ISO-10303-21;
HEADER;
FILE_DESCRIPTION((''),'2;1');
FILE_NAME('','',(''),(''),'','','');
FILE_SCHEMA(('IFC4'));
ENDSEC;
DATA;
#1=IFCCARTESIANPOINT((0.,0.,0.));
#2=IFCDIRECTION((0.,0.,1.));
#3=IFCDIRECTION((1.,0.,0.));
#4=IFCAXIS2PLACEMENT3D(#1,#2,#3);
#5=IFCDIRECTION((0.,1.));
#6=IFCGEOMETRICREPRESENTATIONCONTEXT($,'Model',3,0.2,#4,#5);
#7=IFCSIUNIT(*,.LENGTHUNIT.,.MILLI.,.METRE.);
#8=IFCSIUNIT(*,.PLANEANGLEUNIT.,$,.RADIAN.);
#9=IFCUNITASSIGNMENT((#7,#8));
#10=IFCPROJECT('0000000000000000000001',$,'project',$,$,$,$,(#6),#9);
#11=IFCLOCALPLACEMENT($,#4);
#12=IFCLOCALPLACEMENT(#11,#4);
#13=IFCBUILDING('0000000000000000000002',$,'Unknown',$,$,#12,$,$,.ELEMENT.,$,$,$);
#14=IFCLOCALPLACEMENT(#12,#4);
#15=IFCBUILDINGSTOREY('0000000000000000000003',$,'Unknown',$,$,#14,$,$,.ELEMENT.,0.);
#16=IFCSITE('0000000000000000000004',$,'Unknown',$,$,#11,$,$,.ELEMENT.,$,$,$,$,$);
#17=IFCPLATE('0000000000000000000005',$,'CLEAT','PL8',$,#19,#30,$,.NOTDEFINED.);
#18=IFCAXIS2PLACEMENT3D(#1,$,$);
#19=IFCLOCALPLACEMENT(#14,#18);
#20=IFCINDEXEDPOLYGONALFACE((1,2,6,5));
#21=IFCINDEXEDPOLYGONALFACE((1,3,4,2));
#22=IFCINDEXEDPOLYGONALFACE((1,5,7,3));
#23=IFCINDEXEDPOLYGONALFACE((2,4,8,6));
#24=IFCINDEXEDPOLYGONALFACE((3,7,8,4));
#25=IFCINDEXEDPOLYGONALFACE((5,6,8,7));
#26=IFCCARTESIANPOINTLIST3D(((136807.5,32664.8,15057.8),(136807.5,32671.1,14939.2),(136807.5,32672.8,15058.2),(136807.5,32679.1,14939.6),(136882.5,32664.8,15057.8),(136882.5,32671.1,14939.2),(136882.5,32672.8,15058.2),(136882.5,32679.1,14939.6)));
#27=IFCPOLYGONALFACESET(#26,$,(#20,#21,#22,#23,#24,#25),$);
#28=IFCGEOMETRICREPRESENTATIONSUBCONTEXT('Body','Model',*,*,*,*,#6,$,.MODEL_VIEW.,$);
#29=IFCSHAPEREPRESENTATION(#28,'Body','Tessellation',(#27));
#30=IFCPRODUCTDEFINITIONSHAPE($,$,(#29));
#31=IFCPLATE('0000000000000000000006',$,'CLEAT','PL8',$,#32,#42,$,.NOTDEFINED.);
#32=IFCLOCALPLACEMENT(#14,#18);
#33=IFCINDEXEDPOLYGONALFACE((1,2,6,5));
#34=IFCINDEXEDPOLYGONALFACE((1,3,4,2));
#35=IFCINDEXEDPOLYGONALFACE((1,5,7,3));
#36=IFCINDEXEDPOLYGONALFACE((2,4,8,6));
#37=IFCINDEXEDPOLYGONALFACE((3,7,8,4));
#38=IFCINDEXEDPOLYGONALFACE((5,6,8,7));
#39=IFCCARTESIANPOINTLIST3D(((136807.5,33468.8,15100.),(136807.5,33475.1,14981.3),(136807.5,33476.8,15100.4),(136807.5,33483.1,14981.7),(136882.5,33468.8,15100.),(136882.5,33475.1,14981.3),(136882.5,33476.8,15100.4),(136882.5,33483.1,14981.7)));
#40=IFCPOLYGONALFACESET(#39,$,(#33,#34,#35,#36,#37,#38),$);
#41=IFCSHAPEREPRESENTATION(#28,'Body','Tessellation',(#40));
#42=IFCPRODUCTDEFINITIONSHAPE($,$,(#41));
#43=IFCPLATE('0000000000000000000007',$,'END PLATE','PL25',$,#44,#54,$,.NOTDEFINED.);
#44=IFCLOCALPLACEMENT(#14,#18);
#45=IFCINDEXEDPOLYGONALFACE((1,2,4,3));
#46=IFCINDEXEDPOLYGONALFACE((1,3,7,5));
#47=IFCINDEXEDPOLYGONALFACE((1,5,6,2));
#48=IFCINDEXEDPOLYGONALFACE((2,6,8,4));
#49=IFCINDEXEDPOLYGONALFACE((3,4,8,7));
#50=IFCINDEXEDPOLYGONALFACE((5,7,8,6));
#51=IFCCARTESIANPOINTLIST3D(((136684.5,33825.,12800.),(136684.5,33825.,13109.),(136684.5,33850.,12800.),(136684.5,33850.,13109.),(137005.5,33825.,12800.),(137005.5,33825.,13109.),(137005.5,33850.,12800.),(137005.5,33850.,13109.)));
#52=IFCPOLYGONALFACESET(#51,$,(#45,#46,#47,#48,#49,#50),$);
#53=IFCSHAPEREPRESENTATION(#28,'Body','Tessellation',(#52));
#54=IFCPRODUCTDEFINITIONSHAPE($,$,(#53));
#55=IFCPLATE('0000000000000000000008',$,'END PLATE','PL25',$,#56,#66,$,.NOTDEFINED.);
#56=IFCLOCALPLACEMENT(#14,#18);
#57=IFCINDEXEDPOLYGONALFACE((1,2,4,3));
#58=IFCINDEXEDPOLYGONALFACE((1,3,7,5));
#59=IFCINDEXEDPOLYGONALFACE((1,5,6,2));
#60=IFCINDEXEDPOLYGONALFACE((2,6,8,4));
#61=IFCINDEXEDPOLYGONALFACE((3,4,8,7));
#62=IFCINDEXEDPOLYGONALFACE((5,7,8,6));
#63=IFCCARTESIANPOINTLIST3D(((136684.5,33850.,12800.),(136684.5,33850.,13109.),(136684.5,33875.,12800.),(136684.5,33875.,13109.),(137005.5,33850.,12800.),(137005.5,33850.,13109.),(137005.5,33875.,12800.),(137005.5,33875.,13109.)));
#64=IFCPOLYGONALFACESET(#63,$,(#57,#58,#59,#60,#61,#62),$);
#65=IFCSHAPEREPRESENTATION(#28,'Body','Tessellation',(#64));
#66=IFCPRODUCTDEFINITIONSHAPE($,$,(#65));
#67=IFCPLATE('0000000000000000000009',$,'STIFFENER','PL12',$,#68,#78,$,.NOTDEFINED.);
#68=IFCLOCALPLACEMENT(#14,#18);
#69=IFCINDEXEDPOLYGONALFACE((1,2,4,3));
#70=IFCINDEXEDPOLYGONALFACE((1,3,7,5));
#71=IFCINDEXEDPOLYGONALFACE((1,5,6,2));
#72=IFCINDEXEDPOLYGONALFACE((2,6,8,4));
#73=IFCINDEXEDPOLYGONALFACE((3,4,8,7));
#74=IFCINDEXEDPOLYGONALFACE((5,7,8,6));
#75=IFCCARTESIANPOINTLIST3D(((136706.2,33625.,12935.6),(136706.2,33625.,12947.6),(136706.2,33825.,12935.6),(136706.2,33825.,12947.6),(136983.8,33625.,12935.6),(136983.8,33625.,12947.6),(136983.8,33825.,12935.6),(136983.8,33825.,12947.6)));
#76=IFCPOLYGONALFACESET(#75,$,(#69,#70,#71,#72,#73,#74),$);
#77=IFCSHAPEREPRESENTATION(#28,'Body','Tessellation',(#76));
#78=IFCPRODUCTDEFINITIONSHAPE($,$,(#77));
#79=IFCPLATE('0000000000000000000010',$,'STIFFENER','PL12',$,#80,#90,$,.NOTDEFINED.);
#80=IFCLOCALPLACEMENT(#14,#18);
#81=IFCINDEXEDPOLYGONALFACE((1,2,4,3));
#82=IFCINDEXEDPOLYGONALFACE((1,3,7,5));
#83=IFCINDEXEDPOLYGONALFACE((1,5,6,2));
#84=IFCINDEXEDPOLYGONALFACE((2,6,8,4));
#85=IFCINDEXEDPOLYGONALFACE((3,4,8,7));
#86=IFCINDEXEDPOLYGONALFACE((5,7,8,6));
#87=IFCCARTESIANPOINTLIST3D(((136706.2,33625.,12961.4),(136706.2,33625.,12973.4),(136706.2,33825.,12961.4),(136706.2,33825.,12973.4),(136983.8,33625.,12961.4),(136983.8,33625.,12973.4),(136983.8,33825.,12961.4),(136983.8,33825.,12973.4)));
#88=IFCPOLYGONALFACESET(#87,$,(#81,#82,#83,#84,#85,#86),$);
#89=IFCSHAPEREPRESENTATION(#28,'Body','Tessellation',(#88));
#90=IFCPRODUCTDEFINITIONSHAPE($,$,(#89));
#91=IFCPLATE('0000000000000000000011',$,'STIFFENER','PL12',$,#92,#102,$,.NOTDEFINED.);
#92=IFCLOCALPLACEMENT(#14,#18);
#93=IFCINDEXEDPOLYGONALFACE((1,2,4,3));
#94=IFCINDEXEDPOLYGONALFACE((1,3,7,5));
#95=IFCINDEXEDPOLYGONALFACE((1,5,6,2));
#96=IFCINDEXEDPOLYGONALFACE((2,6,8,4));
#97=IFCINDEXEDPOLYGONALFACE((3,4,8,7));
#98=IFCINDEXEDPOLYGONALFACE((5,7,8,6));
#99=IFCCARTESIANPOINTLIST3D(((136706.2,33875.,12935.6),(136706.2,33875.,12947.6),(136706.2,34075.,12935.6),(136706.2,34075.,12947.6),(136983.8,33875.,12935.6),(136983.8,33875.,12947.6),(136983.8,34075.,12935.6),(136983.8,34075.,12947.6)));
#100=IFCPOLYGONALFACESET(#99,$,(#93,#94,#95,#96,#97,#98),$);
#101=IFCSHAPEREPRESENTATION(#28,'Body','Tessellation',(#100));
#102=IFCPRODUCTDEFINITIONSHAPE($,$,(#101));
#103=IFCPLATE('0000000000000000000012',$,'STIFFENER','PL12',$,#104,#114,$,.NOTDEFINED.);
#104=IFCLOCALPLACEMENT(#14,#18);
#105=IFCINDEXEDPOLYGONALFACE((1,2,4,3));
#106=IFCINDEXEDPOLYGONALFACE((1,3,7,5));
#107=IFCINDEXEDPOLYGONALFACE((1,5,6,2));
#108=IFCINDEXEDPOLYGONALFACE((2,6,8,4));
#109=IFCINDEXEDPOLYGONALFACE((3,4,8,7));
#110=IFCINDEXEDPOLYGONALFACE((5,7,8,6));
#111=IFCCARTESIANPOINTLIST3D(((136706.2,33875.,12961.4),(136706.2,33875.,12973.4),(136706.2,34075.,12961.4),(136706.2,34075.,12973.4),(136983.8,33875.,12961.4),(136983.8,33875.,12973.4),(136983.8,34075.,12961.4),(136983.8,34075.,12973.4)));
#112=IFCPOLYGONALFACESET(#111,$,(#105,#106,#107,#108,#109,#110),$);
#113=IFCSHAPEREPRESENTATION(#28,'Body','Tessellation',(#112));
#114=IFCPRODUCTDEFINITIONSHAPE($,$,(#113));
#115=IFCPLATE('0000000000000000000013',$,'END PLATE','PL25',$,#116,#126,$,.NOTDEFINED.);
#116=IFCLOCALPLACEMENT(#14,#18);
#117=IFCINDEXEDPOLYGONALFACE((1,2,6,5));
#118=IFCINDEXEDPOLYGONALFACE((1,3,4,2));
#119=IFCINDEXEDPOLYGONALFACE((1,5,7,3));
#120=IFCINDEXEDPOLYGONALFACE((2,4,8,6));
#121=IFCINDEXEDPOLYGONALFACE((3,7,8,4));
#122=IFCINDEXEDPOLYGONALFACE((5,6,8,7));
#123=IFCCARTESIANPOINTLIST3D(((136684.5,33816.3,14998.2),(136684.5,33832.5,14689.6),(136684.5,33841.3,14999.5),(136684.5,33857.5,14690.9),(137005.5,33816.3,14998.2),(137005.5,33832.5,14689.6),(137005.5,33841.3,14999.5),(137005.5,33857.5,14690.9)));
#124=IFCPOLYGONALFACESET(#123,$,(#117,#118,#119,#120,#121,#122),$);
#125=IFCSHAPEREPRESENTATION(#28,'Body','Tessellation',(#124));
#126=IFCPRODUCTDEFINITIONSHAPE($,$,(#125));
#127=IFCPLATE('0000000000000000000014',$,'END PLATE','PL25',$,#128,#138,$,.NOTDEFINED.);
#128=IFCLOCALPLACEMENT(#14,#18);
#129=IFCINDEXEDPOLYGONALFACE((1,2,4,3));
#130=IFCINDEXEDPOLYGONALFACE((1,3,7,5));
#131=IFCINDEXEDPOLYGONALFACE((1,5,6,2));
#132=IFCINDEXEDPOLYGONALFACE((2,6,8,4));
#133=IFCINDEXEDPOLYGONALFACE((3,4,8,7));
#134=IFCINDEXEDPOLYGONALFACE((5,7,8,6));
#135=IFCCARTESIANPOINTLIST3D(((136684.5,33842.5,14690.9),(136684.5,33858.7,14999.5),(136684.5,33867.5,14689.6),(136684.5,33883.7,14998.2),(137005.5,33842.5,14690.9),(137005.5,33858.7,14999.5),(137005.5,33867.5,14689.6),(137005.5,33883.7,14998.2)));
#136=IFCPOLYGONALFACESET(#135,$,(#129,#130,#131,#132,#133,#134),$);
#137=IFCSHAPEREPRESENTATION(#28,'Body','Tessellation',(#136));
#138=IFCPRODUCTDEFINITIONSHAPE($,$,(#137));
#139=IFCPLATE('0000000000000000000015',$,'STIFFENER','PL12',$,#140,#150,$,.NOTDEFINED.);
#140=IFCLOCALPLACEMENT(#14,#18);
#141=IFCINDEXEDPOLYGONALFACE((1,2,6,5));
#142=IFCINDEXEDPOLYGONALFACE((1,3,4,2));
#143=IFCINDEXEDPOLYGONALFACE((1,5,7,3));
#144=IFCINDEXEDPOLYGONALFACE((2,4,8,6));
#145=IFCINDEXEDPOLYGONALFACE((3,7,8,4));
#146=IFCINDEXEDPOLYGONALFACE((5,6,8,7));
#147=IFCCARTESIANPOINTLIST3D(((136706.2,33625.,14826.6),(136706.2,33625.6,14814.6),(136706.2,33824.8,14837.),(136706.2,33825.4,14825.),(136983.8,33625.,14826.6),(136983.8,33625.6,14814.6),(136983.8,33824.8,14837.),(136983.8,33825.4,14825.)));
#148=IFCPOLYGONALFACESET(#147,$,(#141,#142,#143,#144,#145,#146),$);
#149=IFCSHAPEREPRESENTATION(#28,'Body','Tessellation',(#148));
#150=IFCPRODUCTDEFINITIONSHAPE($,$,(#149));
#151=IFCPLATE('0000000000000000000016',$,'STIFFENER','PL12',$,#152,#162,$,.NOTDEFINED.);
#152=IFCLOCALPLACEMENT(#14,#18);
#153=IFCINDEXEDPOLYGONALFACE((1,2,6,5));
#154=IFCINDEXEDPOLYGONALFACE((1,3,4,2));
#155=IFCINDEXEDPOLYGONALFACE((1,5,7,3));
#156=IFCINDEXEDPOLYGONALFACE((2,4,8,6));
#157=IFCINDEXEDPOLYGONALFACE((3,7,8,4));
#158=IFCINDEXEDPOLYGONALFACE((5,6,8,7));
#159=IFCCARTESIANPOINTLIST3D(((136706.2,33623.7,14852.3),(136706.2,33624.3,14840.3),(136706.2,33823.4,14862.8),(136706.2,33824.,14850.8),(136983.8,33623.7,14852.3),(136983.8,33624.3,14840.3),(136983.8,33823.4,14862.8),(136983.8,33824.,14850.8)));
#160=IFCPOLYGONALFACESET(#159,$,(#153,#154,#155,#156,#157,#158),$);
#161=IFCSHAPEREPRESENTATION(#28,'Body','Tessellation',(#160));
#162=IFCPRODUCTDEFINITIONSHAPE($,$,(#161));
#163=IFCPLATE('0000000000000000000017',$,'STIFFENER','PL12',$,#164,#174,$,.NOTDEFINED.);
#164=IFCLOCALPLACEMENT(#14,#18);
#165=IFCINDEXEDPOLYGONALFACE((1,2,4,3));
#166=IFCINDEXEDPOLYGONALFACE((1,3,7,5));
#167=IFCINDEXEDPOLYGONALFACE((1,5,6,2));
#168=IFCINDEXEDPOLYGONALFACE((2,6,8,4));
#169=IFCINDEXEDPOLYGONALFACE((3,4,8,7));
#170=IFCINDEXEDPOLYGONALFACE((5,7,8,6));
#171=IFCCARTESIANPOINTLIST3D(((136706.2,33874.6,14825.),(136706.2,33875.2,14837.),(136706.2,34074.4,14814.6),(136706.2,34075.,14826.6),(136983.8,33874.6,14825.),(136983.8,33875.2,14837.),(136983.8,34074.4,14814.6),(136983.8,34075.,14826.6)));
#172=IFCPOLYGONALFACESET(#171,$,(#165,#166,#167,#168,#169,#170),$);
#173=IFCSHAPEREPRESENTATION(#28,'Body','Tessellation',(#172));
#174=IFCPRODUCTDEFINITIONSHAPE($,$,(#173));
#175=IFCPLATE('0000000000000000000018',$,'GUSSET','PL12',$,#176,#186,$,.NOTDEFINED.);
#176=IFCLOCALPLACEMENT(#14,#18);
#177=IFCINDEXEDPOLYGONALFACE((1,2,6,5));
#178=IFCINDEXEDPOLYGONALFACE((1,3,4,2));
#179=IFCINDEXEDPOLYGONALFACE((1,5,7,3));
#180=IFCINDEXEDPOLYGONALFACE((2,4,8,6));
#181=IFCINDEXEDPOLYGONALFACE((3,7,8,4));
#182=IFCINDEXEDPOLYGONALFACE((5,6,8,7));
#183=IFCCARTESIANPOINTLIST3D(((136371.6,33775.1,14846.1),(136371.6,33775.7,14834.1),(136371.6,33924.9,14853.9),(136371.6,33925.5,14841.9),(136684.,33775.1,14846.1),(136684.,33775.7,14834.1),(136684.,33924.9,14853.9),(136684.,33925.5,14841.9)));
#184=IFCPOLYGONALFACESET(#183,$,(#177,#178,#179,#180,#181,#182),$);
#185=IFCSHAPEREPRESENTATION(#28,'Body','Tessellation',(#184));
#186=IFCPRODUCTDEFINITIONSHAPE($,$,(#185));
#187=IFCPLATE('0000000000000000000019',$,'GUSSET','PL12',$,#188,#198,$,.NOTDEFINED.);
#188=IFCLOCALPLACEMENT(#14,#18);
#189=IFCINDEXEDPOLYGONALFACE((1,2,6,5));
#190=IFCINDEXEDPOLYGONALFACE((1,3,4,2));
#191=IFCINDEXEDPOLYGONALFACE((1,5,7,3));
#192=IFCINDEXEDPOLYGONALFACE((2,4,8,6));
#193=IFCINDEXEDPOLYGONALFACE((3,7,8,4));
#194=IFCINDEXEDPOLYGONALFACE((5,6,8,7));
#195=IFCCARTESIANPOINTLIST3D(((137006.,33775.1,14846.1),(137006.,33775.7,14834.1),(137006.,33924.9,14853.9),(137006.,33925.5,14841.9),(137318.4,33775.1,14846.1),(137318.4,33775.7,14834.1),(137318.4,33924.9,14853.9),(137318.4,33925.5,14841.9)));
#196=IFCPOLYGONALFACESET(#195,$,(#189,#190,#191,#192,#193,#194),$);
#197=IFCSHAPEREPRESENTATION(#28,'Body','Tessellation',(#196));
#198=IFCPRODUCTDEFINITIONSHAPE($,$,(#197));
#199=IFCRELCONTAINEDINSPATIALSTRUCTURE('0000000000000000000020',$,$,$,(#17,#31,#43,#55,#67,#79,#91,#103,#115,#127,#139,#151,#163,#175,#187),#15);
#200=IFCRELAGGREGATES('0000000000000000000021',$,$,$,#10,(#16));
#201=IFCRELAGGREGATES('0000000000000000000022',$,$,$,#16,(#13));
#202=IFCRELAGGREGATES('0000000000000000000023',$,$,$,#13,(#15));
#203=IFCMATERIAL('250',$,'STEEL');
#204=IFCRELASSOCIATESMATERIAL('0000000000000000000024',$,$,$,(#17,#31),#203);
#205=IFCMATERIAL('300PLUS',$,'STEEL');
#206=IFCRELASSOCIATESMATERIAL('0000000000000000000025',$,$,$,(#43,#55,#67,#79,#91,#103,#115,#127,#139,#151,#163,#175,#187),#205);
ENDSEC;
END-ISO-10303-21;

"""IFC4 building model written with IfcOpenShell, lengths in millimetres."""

from ifc_helpers import new_model, si_unit, direction, frame, origin_with_axes, place, context, subcontext, project, spatial, line, indexed_curve, outline, extrude, material, element, save


model = new_model("IFC4")

# Units and contexts
model_context = context("Model", 3, precision=0.2, world=origin_with_axes(), true_north=direction((0.0, 1.0)))
body_context = subcontext(model_context, "Body", "Model", "MODEL_VIEW")
ifc_project = project(units=[si_unit("LENGTHUNIT", "METRE", prefix="MILLI"), si_unit("PLANEANGLEUNIT", "RADIAN")], contexts=[model_context])

# Site, building, storey
site_placement = place(None, origin_with_axes())
site = spatial("IfcSite", under=ifc_project, at=site_placement, Name="Unknown", CompositionType="ELEMENT")
building_placement = place(site_placement, origin_with_axes())
building = spatial("IfcBuilding", under=site, at=building_placement, Name="Unknown", CompositionType="ELEMENT")
storey_placement = place(building_placement, origin_with_axes())
storey = spatial("IfcBuildingStorey", under=building, at=storey_placement, Name="Unknown", CompositionType="ELEMENT", Elevation=0.0)

# Shared definitions
ifc_material_1 = material(Name="300PLUS", Category="STEEL")

# Plates
ifc_material_2 = material(Name="250", Category="STEEL")
plate_1_placement = place(storey_placement, frame((136807.5, 32668.8, 15058.0), z_axis=(0.0, 0.998592, 0.053045), x_axis=(1.0, 0.0, 0.0)))
element("IfcPlate", 1, at=plate_1_placement, inside=storey, material=ifc_material_2, Name="CLEAT", Description="PL8", PredefinedType="NOTDEFINED", context=body_context, shape_type="SolidModel", body=[
    extrude(outline(indexed_curve([(0.0, 0.0), (75.0, 0.0), (75.0, 118.8), (0.0, 118.8)], segments=[line(1, 2, 3, 4, 1)])), frame((0.0, 0.0, 4.0), z_axis=(0.0, 0.0, 1.0), x_axis=(1.0, 0.0, 0.0)), (0.0, 0.0, -1.0), 8.0),
])
plate_2_placement = place(storey_placement, frame((136807.5, 33472.8, 15100.2), z_axis=(0.0, 0.998594, 0.053), x_axis=(1.0, 0.0, 0.0)))
element("IfcPlate", 2, at=plate_2_placement, inside=storey, material=ifc_material_2, Name="CLEAT", Description="PL8", PredefinedType="NOTDEFINED", context=body_context, shape_type="SolidModel", body=[
    extrude(outline(indexed_curve([(0.0, 0.0), (75.0, 0.0), (75.0, 118.9), (0.0, 118.9)], segments=[line(1, 2, 3, 4, 1)])), frame((0.0, 0.0, 4.0), z_axis=(0.0, 0.0, 1.0), x_axis=(1.0, 0.0, 0.0)), (0.0, 0.0, -1.0), 8.0),
])
for number, where, z_axis, x_axis, name in (
    (3, (137005.5, 33837.5, 12800.0), (0.0, -1.0, 0.0), (0.0, 0.0, 1.0), "END PLATE"),
    (4, (136684.5, 33862.5, 12800.0), (0.0, 1.0, 0.0), (0.0, 0.0, 1.0), "END PLATE"),
):
    element("IfcPlate", number, at=place(storey_placement, frame(where, z_axis=z_axis, x_axis=x_axis)), inside=storey, material=ifc_material_1, Name=name, Description="PL25", PredefinedType="NOTDEFINED", context=body_context, shape_type="SolidModel", body=[
        extrude(outline(indexed_curve([(0.0, 0.0), (309.0, 0.0), (309.0, 321.0), (0.0, 321.0)], segments=[line(1, 2, 3, 4, 1)])), frame((0.0, 0.0, 12.5), z_axis=(0.0, 0.0, 1.0), x_axis=(1.0, 0.0, 0.0)), (0.0, 0.0, -1.0), 25.0),
    ])
for number, where, z_axis, x_axis, name in (
    (5, (136983.8, 33625.0, 12941.6), (0.0, 0.0, 1.0), (0.0, 1.0, 0.0), "STIFFENER"),
    (6, (136983.8, 33625.0, 12967.4), (0.0, 0.0, 1.0), (0.0, 1.0, 0.0), "STIFFENER"),
    (7, (136706.2, 34075.0, 12941.6), (0.0, 0.0, 1.0), (0.0, -1.0, 0.0), "STIFFENER"),
    (8, (136706.2, 34075.0, 12967.4), (0.0, 0.0, 1.0), (0.0, -1.0, 0.0), "STIFFENER"),
):
    element("IfcPlate", number, at=place(storey_placement, frame(where, z_axis=z_axis, x_axis=x_axis)), inside=storey, material=ifc_material_1, Name=name, Description="PL12", PredefinedType="NOTDEFINED", context=body_context, shape_type="SolidModel", body=[
        extrude(outline(indexed_curve([(0.0, 0.0), (200.0, 0.0), (200.0, 277.6), (0.0, 277.6)], segments=[line(1, 2, 3, 4, 1)])), frame((0.0, 0.0, 6.0), z_axis=(0.0, 0.0, 1.0), x_axis=(1.0, 0.0, 0.0)), (0.0, 0.0, -1.0), 12.0),
    ])
for number, where, z_axis, x_axis, name in (
    (9, (136684.5, 33845.0, 14690.3), (0.0, 0.998625, 0.052423), (0.0, -0.052423, 0.998625), "END PLATE"),
    (10, (137005.5, 33855.0, 14690.3), (0.0, -0.998625, 0.052423), (0.0, 0.052423, 0.998625), "END PLATE"),
):
    element("IfcPlate", number, at=place(storey_placement, frame(where, z_axis=z_axis, x_axis=x_axis)), inside=storey, material=ifc_material_1, Name=name, Description="PL25", PredefinedType="NOTDEFINED", context=body_context, shape_type="SolidModel", body=[
        extrude(outline(indexed_curve([(0.0, 0.0), (309.0, 0.0), (309.0, 321.0), (0.0, 321.0)], segments=[line(1, 2, 3, 4, 1)])), frame((0.0, 0.0, 12.5), z_axis=(0.0, 0.0, 1.0), x_axis=(1.0, 0.0, 0.0)), (0.0, 0.0, -1.0), 25.0),
    ])
plate_3_placement = place(storey_placement, frame((136983.8, 33625.3, 14820.6), z_axis=(0.0, -0.051982, 0.998648), x_axis=(0.0, 0.998648, 0.051982)))
element("IfcPlate", 11, at=plate_3_placement, inside=storey, material=ifc_material_1, Name="STIFFENER", Description="PL12", PredefinedType="NOTDEFINED", context=body_context, shape_type="SolidModel", body=[
    extrude(outline(indexed_curve([(0.0, 0.0), (200.1, 0.0), (200.1, 277.6), (0.0, 277.6)], segments=[line(1, 2, 3, 4, 1)])), frame((0.0, 0.0, 6.0), z_axis=(0.0, 0.0, 1.0), x_axis=(1.0, 0.0, 0.0)), (0.0, 0.0, -1.0), 12.0),
])
plate_4_placement = place(storey_placement, frame((136983.8, 33624.0, 14846.3), z_axis=(0.0, -0.052506, 0.998621), x_axis=(0.0, 0.998621, 0.052506)))
element("IfcPlate", 12, at=plate_4_placement, inside=storey, material=ifc_material_1, Name="STIFFENER", Description="PL12", PredefinedType="NOTDEFINED", context=body_context, shape_type="SolidModel", body=[
    extrude(outline(indexed_curve([(0.0, 0.0), (200.0, 0.0), (200.0, 277.6), (0.0, 277.6)], segments=[line(1, 2, 3, 4, 1)])), frame((0.0, 0.0, 6.0), z_axis=(0.0, 0.0, 1.0), x_axis=(1.0, 0.0, 0.0)), (0.0, 0.0, -1.0), 12.0),
])
plate_5_placement = place(storey_placement, frame((136706.2, 34074.7, 14820.6), z_axis=(0.0, 0.051982, 0.998648), x_axis=(0.0, -0.998648, 0.051982)))
element("IfcPlate", 13, at=plate_5_placement, inside=storey, material=ifc_material_1, Name="STIFFENER", Description="PL12", PredefinedType="NOTDEFINED", context=body_context, shape_type="SolidModel", body=[
    extrude(outline(indexed_curve([(0.0, 0.0), (200.1, 0.0), (200.1, 277.6), (0.0, 277.6)], segments=[line(1, 2, 3, 4, 1)])), frame((0.0, 0.0, 6.0), z_axis=(0.0, 0.0, 1.0), x_axis=(1.0, 0.0, 0.0)), (0.0, 0.0, -1.0), 12.0),
])
for number, where, z_axis, x_axis, name in (
    (14, (136684.0, 33925.2, 14847.9), (0.0, -0.051999, 0.998647), (-1.0, 0.0, 0.0), "GUSSET"),
    (15, (137006.0, 33775.4, 14840.1), (0.0, -0.051999, 0.998647), (1.0, 0.0, 0.0), "GUSSET"),
):
    element("IfcPlate", number, at=place(storey_placement, frame(where, z_axis=z_axis, x_axis=x_axis)), inside=storey, material=ifc_material_1, Name=name, Description="PL12", PredefinedType="NOTDEFINED", context=body_context, shape_type="SolidModel", body=[
        extrude(outline(indexed_curve([(0.0, 0.0), (312.4, 0.0), (312.4, 150.0), (0.0, 150.0)], segments=[line(1, 2, 3, 4, 1)])), frame((0.0, 0.0, 6.0), z_axis=(0.0, 0.0, 1.0), x_axis=(1.0, 0.0, 0.0)), (0.0, 0.0, -1.0), 12.0),
    ])

save(model, "model.ifc")
